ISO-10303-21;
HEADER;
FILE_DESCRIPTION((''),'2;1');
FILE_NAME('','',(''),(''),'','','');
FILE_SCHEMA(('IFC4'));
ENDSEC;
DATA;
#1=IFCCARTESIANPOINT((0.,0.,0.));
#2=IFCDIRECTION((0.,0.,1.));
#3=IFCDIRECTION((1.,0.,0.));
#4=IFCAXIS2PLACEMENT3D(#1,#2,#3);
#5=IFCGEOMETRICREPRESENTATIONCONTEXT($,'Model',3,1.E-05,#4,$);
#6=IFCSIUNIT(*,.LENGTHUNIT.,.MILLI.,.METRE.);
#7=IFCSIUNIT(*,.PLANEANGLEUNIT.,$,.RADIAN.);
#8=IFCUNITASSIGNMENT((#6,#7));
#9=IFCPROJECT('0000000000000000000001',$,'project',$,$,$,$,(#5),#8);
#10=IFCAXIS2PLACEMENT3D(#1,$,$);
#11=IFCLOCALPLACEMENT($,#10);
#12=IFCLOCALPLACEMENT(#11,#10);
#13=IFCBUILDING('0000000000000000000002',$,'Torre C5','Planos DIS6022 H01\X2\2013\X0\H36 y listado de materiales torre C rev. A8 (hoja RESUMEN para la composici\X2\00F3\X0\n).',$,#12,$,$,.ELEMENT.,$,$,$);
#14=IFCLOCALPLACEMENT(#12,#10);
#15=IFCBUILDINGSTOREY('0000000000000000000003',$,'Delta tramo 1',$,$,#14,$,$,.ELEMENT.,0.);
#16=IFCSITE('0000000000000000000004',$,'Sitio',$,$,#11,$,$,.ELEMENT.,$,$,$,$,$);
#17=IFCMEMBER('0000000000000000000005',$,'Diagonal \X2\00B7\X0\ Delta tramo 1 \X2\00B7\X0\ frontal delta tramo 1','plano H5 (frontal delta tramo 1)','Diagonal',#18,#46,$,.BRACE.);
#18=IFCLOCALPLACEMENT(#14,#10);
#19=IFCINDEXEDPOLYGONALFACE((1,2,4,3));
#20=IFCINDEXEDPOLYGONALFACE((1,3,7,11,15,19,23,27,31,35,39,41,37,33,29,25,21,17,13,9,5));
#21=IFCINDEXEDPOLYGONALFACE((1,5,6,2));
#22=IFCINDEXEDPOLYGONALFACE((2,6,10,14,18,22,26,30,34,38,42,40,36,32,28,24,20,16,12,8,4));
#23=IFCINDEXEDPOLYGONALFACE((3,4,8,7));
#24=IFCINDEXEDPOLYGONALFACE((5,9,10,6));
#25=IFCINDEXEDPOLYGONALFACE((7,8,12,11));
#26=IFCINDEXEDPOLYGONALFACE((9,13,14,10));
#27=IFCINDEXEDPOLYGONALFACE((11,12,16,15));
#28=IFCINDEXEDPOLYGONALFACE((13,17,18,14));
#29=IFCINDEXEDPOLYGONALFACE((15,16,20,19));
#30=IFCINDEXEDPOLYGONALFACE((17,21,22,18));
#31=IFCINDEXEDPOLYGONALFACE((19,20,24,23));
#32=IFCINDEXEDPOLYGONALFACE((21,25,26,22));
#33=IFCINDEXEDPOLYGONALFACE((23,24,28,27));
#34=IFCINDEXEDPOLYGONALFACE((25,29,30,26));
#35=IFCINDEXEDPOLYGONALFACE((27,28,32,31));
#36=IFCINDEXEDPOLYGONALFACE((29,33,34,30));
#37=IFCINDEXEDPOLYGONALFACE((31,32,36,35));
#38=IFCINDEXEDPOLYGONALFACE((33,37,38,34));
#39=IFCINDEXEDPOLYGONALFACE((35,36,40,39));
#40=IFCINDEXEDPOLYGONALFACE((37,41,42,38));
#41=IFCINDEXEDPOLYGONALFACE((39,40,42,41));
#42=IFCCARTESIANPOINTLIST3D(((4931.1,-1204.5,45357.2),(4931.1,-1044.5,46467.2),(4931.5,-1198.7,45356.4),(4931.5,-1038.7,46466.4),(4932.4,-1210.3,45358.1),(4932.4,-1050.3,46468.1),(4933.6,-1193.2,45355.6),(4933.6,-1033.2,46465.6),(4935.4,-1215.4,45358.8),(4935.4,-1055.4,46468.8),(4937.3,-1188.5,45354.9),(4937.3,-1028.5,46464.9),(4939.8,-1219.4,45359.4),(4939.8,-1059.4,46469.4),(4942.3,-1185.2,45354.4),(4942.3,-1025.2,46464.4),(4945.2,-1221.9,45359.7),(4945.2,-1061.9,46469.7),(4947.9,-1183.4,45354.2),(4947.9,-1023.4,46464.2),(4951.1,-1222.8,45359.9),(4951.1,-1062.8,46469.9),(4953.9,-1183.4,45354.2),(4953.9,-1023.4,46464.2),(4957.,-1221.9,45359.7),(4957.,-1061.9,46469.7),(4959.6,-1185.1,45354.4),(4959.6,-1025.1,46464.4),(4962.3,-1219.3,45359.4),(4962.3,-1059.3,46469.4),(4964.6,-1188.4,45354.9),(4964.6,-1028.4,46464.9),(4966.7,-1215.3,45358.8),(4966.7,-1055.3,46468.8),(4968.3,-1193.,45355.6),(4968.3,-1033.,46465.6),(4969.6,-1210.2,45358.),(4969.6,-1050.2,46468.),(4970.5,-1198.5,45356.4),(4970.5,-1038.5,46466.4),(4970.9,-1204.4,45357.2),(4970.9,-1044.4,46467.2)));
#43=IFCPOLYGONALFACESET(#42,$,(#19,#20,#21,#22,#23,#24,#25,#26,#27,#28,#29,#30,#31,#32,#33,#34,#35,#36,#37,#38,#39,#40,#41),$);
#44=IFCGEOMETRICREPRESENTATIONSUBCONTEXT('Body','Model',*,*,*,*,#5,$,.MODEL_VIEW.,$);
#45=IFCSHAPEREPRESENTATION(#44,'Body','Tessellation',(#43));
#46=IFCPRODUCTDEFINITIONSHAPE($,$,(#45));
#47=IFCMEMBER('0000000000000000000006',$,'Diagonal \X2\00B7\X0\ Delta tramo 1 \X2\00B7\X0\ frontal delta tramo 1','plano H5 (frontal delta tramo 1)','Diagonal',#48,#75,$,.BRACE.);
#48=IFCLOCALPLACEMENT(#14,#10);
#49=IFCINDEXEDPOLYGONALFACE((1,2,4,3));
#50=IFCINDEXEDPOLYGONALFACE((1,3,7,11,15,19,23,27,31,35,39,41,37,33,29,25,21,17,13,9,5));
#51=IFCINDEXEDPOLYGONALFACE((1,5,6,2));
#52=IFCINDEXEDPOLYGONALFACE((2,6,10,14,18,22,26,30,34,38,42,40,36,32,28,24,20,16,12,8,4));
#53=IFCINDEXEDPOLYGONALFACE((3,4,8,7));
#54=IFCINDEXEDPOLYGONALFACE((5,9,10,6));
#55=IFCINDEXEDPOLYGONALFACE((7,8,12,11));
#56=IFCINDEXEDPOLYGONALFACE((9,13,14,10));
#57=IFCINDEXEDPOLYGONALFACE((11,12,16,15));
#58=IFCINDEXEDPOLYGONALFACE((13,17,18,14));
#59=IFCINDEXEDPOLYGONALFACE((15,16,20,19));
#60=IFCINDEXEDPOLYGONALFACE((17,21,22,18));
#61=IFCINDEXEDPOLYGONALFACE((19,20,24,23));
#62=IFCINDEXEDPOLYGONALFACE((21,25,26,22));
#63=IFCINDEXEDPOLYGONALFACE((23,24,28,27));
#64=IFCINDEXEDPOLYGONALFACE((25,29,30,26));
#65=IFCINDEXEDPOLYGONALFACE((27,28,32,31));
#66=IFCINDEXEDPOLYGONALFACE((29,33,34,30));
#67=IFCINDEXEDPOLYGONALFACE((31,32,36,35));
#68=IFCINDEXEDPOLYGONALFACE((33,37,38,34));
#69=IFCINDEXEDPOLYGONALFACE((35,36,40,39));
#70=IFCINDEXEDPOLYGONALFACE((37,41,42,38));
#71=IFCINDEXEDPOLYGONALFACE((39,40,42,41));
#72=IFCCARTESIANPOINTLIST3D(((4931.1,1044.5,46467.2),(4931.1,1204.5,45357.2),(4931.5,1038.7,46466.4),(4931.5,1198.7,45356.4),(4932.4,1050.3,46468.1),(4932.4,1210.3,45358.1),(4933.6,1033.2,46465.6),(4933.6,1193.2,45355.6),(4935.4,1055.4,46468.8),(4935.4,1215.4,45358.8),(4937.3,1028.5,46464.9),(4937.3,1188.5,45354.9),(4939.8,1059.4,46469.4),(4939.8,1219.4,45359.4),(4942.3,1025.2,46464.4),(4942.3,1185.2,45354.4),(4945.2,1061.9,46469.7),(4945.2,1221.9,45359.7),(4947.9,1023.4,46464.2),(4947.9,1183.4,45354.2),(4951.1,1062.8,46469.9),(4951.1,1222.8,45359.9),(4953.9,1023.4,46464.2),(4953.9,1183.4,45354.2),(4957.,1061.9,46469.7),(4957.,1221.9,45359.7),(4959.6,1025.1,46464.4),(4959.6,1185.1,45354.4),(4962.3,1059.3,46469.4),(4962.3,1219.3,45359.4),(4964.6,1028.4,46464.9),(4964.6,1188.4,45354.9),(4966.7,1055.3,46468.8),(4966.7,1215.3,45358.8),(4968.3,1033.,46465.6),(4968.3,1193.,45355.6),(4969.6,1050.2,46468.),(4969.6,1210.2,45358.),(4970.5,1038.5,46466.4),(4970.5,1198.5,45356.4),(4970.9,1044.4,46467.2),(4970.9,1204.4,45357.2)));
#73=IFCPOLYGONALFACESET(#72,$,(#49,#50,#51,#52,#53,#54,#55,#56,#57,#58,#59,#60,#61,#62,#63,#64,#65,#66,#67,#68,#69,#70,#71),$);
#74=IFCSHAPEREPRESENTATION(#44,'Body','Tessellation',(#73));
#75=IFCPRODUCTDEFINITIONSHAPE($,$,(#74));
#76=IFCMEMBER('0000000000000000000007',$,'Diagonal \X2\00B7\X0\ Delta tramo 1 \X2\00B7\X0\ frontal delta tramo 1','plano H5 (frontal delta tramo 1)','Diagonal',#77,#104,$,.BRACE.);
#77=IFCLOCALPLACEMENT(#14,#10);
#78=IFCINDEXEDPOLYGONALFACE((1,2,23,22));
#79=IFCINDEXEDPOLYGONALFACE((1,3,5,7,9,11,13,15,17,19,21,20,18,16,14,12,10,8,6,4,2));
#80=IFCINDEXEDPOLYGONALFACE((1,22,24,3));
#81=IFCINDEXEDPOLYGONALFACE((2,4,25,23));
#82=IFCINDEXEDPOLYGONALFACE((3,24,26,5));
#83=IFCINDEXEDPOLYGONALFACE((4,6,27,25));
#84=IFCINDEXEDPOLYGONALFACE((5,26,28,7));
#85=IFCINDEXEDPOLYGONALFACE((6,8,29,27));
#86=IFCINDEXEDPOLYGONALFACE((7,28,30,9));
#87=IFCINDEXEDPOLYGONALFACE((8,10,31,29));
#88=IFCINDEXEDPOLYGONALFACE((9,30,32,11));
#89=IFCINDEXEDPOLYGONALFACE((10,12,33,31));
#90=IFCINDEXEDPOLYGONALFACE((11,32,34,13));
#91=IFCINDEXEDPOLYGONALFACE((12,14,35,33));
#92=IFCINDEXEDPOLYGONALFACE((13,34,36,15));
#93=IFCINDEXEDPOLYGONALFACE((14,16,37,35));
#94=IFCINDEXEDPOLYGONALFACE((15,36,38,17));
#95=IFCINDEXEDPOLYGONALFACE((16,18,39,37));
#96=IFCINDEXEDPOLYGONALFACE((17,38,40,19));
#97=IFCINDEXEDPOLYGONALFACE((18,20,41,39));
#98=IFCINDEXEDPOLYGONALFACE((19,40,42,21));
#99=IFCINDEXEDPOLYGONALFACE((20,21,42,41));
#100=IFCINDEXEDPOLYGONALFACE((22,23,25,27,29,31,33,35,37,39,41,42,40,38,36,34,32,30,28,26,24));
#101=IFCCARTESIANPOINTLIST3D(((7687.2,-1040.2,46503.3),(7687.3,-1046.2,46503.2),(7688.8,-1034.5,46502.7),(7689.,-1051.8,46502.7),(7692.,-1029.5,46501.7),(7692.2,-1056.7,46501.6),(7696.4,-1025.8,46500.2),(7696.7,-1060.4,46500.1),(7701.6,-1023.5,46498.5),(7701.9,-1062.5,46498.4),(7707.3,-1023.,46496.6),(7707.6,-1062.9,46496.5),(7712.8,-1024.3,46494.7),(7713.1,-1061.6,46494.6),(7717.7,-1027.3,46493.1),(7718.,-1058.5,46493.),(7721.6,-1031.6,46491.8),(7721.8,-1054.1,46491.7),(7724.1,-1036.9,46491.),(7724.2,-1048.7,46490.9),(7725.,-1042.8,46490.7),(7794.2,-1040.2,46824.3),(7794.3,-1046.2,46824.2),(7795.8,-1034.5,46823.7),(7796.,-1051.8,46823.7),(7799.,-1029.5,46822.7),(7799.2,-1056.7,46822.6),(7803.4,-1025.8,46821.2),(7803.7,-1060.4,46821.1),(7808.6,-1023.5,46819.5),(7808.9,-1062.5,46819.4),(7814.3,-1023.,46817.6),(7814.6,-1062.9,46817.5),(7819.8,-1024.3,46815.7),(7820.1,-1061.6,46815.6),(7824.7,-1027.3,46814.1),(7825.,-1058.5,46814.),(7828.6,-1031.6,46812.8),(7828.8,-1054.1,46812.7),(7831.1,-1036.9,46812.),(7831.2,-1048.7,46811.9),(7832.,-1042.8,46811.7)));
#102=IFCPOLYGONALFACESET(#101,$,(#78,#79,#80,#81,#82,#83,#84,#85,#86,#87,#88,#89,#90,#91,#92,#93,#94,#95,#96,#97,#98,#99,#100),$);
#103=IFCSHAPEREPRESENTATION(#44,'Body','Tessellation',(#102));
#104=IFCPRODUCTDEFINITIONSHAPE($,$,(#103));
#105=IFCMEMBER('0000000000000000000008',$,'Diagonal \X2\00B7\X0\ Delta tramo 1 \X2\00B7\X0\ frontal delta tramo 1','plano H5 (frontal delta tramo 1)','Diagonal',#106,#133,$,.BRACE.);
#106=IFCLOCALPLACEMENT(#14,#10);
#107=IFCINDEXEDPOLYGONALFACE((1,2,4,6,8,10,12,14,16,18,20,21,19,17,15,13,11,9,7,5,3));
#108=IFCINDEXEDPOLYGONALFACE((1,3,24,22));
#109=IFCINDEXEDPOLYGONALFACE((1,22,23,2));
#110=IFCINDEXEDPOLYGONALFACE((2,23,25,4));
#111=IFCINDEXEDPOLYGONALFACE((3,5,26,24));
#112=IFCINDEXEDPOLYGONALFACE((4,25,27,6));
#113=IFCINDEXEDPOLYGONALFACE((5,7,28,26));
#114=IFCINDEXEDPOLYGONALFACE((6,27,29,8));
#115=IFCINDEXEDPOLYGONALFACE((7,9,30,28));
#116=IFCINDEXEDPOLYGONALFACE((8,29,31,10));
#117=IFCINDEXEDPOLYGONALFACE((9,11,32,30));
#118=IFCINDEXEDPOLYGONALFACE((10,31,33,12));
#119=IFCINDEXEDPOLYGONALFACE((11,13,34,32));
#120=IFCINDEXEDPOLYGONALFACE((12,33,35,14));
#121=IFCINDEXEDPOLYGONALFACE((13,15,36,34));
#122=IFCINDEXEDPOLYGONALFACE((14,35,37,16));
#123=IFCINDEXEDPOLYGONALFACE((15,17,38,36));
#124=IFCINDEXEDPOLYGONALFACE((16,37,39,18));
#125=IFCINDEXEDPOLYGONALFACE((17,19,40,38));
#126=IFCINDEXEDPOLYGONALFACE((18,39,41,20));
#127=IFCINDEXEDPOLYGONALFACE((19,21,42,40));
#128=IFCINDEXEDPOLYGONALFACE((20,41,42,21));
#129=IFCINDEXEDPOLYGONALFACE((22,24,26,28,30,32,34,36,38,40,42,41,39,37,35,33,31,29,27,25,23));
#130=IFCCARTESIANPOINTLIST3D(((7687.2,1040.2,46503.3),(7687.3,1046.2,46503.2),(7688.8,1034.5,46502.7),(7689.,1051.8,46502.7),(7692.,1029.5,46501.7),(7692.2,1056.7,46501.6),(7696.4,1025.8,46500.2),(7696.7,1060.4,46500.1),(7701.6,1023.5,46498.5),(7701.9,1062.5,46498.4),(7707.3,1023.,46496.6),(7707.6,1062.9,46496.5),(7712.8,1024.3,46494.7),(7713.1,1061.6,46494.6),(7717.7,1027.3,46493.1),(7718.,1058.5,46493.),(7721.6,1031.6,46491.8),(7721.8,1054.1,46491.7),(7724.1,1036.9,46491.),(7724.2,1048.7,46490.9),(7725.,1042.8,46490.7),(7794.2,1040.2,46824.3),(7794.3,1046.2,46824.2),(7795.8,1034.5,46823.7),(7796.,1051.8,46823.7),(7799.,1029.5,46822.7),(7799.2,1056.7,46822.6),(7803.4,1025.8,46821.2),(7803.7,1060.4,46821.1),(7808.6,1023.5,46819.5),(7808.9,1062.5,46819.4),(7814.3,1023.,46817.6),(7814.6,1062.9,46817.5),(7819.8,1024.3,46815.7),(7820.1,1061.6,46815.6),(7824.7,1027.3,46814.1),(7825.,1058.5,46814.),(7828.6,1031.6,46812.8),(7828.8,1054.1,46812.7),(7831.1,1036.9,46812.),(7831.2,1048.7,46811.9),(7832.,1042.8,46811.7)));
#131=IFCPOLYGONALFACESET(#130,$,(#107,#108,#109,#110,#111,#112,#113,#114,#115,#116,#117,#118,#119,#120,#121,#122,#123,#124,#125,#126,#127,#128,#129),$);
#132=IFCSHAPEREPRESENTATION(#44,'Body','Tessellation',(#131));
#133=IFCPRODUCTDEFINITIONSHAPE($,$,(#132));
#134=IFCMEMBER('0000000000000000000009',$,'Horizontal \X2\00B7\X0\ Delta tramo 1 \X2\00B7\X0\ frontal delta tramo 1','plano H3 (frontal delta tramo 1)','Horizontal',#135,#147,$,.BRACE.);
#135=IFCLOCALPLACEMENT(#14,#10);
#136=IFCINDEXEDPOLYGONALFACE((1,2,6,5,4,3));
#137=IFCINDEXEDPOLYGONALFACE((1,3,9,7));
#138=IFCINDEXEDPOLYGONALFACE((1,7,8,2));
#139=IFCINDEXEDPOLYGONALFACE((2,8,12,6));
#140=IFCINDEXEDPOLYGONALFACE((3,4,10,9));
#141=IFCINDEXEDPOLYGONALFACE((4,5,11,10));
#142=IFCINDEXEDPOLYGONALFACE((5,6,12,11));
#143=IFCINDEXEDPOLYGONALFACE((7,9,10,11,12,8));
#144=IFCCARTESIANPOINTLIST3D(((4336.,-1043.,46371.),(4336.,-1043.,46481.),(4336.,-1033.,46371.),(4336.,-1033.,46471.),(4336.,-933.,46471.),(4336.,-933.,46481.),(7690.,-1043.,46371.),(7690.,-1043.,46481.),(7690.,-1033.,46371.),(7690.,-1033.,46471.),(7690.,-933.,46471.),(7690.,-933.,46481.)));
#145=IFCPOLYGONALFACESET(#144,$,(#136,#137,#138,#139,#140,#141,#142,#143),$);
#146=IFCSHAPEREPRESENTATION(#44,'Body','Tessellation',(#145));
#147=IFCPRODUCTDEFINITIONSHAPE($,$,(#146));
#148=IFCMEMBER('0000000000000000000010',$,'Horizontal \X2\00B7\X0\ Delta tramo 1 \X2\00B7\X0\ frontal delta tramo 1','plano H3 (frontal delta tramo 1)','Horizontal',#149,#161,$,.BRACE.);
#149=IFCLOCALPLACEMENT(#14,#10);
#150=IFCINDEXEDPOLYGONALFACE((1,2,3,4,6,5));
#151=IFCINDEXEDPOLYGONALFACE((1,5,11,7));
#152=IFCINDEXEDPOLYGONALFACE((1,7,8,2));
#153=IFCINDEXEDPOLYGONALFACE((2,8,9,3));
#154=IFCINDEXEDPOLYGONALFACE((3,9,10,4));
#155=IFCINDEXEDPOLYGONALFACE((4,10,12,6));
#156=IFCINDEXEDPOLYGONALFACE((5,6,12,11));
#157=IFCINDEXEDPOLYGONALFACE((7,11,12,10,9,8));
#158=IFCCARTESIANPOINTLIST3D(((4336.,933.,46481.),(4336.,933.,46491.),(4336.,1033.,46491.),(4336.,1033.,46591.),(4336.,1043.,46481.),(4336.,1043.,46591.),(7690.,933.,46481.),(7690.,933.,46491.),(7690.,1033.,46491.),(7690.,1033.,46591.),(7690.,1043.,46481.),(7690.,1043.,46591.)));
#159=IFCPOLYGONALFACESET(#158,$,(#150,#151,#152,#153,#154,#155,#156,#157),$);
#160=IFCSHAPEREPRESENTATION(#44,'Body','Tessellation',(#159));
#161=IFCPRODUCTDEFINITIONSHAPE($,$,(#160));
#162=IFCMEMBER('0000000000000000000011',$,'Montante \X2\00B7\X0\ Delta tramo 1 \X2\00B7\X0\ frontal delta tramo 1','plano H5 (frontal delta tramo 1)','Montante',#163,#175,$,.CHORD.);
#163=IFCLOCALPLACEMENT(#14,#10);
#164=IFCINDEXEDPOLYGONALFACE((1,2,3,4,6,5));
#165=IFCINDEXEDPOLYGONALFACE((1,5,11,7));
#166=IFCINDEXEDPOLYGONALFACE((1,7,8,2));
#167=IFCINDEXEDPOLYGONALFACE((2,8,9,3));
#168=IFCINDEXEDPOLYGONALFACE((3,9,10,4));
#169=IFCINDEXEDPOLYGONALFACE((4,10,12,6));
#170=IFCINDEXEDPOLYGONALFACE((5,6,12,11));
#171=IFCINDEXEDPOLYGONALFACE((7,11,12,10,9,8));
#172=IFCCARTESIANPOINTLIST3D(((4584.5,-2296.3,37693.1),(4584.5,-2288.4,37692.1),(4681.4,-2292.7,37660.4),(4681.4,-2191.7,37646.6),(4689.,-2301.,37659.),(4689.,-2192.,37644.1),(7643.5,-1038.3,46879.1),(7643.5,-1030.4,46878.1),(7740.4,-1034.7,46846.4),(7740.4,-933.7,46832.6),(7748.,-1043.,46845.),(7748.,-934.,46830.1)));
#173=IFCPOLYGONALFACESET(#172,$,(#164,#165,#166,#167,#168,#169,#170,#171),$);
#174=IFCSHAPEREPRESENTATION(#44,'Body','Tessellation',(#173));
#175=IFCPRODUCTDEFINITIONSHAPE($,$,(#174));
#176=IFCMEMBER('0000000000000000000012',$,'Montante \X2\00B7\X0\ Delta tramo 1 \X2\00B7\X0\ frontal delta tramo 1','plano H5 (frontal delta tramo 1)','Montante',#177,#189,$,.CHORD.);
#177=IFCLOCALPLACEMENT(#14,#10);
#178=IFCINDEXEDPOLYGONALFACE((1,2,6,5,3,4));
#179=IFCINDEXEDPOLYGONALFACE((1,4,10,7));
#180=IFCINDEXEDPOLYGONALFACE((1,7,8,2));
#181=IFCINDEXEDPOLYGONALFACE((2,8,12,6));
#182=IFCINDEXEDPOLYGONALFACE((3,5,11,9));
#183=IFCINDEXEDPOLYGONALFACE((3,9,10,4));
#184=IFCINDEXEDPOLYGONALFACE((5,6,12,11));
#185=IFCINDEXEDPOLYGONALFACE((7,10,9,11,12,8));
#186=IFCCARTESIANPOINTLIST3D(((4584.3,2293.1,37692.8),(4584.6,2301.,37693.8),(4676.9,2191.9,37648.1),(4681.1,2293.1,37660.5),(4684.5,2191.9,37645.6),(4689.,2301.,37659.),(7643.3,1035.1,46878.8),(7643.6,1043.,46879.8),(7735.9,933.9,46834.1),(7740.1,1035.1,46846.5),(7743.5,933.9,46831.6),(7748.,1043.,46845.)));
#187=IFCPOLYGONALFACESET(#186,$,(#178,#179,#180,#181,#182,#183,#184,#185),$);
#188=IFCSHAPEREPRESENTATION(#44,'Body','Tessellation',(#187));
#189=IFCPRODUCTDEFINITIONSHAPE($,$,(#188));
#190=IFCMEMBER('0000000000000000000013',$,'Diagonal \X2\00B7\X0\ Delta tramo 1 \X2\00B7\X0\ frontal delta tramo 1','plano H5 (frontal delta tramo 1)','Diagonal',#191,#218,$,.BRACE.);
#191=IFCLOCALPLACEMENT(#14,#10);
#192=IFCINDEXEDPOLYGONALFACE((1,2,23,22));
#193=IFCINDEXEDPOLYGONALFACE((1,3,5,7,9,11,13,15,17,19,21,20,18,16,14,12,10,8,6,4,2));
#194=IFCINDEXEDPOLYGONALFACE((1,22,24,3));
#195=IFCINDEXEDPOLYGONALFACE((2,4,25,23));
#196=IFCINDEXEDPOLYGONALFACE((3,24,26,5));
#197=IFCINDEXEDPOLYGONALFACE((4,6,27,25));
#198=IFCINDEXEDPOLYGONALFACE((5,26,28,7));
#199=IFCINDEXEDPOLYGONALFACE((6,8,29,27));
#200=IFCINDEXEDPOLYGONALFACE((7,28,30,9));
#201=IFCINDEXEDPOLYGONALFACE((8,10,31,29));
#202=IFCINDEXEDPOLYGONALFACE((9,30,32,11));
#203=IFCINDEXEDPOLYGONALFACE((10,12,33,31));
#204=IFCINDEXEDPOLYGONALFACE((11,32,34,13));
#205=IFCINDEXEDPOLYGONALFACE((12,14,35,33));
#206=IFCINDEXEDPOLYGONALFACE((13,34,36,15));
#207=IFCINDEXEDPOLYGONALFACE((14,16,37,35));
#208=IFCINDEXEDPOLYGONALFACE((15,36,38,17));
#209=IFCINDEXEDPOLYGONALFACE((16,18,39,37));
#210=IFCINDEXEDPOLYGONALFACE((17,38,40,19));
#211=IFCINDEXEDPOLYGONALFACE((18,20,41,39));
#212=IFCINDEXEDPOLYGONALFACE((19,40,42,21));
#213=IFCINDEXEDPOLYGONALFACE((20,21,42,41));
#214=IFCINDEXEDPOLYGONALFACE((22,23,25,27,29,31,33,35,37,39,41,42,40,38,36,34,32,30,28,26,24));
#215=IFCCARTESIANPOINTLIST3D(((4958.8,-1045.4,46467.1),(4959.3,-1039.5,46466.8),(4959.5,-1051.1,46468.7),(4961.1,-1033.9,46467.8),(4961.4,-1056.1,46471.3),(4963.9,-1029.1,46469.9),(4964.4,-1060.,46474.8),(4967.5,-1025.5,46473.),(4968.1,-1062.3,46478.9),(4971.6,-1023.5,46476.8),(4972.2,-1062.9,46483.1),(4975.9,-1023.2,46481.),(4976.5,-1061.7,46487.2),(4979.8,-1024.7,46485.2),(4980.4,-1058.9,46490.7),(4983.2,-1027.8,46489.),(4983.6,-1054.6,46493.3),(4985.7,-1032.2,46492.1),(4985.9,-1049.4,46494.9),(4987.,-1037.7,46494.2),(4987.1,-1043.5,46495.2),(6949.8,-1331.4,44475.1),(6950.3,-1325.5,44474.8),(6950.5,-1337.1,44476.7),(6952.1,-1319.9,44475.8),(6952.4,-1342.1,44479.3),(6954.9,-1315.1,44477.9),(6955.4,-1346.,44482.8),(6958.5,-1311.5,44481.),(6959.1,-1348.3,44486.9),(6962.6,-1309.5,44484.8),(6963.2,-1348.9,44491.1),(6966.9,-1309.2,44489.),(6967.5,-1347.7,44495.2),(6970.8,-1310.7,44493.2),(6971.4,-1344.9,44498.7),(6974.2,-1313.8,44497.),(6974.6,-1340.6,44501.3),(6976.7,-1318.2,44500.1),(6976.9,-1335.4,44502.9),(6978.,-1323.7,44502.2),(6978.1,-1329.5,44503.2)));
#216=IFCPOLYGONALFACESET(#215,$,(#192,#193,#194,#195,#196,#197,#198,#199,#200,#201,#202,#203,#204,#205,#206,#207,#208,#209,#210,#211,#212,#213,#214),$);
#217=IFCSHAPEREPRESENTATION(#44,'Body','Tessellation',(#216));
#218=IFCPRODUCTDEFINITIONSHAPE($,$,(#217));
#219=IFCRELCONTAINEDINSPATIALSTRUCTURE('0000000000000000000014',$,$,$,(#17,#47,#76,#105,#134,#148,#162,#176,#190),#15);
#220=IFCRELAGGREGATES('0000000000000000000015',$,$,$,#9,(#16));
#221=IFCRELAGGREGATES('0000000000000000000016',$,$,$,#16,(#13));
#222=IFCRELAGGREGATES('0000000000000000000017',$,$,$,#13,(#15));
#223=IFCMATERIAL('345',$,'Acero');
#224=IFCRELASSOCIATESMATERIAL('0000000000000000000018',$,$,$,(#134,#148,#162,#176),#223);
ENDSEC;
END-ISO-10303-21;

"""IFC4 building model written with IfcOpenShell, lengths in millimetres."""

from ifc_helpers import new_model, si_unit, frame, frame_2d, origin, origin_with_axes, place, context, subcontext, project, spatial, circle, l_section, extrude, material, element, save


model = new_model("IFC4")

# Units and contexts
model_context = context("Model", 3, precision=1e-05, world=origin_with_axes())
body_context = subcontext(model_context, "Body", "Model", "MODEL_VIEW")
ifc_project = project(units=[si_unit("LENGTHUNIT", "METRE", prefix="MILLI"), si_unit("PLANEANGLEUNIT", "RADIAN")], contexts=[model_context])

# Site, building, storey
site_placement = place(None, origin())
site = spatial("IfcSite", under=ifc_project, at=site_placement, Name="Sitio", CompositionType="ELEMENT")
building_placement = place(site_placement, origin())
building = spatial("IfcBuilding", under=site, at=building_placement, Name="Torre C5", Description="Planos DIS6022 H01–H36 y listado de materiales torre C rev. A8 (hoja RESUMEN para la composición).", CompositionType="ELEMENT")
storey_placement = place(building_placement, origin())
storey = spatial("IfcBuildingStorey", under=building, at=storey_placement, Name="Delta tramo 1", CompositionType="ELEMENT", Elevation=0.0)

# Members
for number, where, z_axis, x_axis, name in (
    (1, (4951.0, -1203.0, 45357.0), (0.0, 0.14267, 0.98977), (-0.975714, 0.216809, -0.031252), "Diagonal · Delta tramo 1 · frontal delta tramo 1"),
    (2, (4951.0, 1203.0, 45357.0), (0.0, -0.14267, 0.98977), (-0.975714, -0.216809, -0.031252), "Diagonal · Delta tramo 1 · frontal delta tramo 1"),
):
    element("IfcMember", number, at=place(storey_placement, frame(where, z_axis=z_axis, x_axis=x_axis)), inside=storey, Name=name, Description="plano H5 (frontal delta tramo 1)", ObjectType="Diagonal", PredefinedType="BRACE", context=body_context, shape_type="SweptSolid", body=[
        extrude(circle(Radius=20.0), None, (0.0, 0.0, 1.0), 1121.5),
    ])
for number, where, z_axis, x_axis, name in (
    (3, (7706.0, -1043.0, 46497.0), (0.316228, 0.0, 0.948683), (-0.939302, 0.140286, 0.313101), "Diagonal · Delta tramo 1 · frontal delta tramo 1"),
    (4, (7706.0, 1043.0, 46497.0), (0.316228, 0.0, 0.948683), (-0.939302, -0.140286, 0.313101), "Diagonal · Delta tramo 1 · frontal delta tramo 1"),
):
    element("IfcMember", number, at=place(storey_placement, frame(where, z_axis=z_axis, x_axis=x_axis)), inside=storey, Name=name, Description="plano H5 (frontal delta tramo 1)", ObjectType="Diagonal", PredefinedType="BRACE", context=body_context, shape_type="SweptSolid", body=[
        extrude(circle(Radius=20.0), None, (0.0, 0.0, 1.0), 338.4),
    ])
ifc_material = material(Name="345", Category="Acero")
for number, where, z_axis, x_axis, name in (
    (5, (7690.0, -1043.0, 46481.0), (-1.0, 0.0, 0.0), (0.0, 1.0, 0.0), "Horizontal · Delta tramo 1 · frontal delta tramo 1"),
    (6, (7690.0, 1043.0, 46481.0), (-1.0, 0.0, 0.0), (0.0, -1.0, 0.0), "Horizontal · Delta tramo 1 · frontal delta tramo 1"),
):
    element("IfcMember", number, at=place(storey_placement, frame(where, z_axis=z_axis, x_axis=x_axis)), inside=storey, material=ifc_material, Name=name, Description="plano H3 (frontal delta tramo 1)", ObjectType="Horizontal", PredefinedType="BRACE", context=body_context, shape_type="SweptSolid", body=[
        extrude(l_section(Depth=110.0, Width=110.0, Thickness=10.0, at=frame_2d((55.0, 55.0))), None, (0.0, 0.0, 1.0), 3354.0),
    ])
for number, where, z_axis, x_axis, name in (
    (7, (7748.0, -1043.0, 46845.0), (-0.313315, -0.128849, -0.940867), (-0.949649, 0.042511, 0.310418), "Montante · Delta tramo 1 · frontal delta tramo 1"),
    (8, (7748.0, 1043.0, 46845.0), (-0.313315, 0.128849, -0.940867), (-0.04071, -0.991664, -0.122249), "Montante · Delta tramo 1 · frontal delta tramo 1"),
):
    element("IfcMember", number, at=place(storey_placement, frame(where, z_axis=z_axis, x_axis=x_axis)), inside=storey, material=ifc_material, Name=name, Description="plano H5 (frontal delta tramo 1)", ObjectType="Montante", PredefinedType="CHORD", context=body_context, shape_type="SweptSolid", body=[
        extrude(l_section(Depth=110.0, Width=110.0, Thickness=8.0, at=frame_2d((55.0, 55.0))), None, (0.0, 0.0, 1.0), 9763.3),
    ])
for number, where, z_axis, x_axis, name in (
    (9, (4973.0, -1043.0, 46481.0), (0.703312, -0.101028, -0.703666), (-0.683723, 0.174854, -0.708484), "Diagonal · Delta tramo 1 · frontal delta tramo 1"),
):
    element("IfcMember", number, at=place(storey_placement, frame(where, z_axis=z_axis, x_axis=x_axis)), inside=storey, Name=name, Description="plano H5 (frontal delta tramo 1)", ObjectType="Diagonal", PredefinedType="BRACE", context=body_context, shape_type="SweptSolid", body=[
        extrude(circle(Radius=20.0), None, (0.0, 0.0, 1.0), 2830.9),
    ])

save(model, "model.ifc")
